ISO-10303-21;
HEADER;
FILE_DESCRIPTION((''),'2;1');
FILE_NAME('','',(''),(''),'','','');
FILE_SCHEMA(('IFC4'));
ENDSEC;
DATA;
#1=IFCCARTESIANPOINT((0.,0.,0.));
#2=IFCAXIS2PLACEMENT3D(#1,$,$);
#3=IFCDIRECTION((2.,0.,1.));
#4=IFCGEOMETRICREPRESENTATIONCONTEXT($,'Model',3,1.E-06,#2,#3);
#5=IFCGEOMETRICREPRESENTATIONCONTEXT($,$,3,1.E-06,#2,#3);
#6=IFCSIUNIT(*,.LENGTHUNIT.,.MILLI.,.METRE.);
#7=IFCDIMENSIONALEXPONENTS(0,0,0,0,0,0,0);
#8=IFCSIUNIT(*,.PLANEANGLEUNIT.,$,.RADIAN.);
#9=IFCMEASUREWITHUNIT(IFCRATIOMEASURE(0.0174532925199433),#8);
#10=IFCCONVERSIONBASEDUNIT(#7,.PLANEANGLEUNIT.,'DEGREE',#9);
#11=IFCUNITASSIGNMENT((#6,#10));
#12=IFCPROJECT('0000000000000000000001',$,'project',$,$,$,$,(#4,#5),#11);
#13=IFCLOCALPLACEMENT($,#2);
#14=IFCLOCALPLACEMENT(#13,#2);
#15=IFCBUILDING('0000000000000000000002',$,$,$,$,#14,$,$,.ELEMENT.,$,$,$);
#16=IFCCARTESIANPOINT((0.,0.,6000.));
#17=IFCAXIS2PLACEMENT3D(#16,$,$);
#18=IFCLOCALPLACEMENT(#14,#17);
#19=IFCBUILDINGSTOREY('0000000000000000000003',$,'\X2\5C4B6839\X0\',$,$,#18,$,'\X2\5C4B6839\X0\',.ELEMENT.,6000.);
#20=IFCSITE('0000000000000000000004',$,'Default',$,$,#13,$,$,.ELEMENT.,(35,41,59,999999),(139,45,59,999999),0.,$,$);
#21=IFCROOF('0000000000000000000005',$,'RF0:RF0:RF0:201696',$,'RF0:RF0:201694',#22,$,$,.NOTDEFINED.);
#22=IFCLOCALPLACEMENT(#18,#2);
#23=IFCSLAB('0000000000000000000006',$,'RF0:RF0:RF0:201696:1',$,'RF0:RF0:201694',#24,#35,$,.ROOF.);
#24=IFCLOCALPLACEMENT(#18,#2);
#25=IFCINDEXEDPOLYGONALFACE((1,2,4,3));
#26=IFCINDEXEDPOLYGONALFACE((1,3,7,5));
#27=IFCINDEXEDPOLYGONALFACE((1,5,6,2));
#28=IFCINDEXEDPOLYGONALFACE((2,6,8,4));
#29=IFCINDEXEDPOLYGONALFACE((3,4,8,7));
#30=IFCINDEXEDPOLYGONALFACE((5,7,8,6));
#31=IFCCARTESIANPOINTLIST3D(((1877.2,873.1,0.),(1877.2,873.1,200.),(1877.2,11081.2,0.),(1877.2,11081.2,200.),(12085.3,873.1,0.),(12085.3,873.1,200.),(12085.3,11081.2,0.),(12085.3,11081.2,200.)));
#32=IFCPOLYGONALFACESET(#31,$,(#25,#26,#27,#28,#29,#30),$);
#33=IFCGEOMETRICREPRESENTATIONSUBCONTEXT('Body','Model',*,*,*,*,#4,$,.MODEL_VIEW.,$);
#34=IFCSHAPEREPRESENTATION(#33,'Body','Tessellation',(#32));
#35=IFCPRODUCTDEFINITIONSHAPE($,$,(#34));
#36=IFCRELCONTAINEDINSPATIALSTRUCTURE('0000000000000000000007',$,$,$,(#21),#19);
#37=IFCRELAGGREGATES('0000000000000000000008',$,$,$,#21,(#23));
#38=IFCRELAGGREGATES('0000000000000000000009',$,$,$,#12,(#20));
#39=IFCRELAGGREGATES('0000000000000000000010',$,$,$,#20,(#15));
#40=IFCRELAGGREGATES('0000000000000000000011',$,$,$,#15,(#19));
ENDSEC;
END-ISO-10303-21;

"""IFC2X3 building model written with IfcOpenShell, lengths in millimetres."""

from ifc_helpers import new_model, entity, si_unit, converted_unit, direction, frame, frame_2d, origin, place, context, subcontext, project, spatial, rectangle, extrude, element, aggregate, save


model = new_model("IFC2X3")

# Units and contexts
model_context = context("Model", 3, precision=1e-06, world=origin(), true_north=direction((2.0, 0.0, 1.0)))
context_of_model = context(None, 3, precision=1e-06, world=origin(), true_north=direction((2.0, 0.0, 1.0)))
body_context = subcontext(model_context, "Body", "Model", "MODEL_VIEW")
ifc_project = project(units=[si_unit("LENGTHUNIT", "METRE", prefix="MILLI"), converted_unit("PLANEANGLEUNIT", "DEGREE", entity("IfcRatioMeasure", 0.0174532925199433), si_unit("PLANEANGLEUNIT", "RADIAN"), dimensions=[0, 0, 0, 0, 0, 0, 0])], contexts=[model_context, context_of_model])

# Site, building, storey
site_placement = place(None, origin())
site = spatial("IfcSite", under=ifc_project, at=site_placement, Name="Default", CompositionType="ELEMENT", RefLatitude=(35, 41, 59, 999999), RefLongitude=(139, 45, 59, 999999), RefElevation=0.0)
building_placement = place(site_placement, origin())
building = spatial("IfcBuilding", under=site, at=building_placement, CompositionType="ELEMENT")
storey_placement = place(building_placement, frame((0.0, 0.0, 6000.0)))
storey = spatial("IfcBuildingStorey", under=building, at=storey_placement, Name="屋根", LongName="屋根", CompositionType="ELEMENT", Elevation=6000.0)

# Roof, slab
roof_placement = place(storey_placement, origin())
roof = element("IfcRoof", 1, at=roof_placement, inside=storey, Name="RF0:RF0:RF0:201696", ObjectType="RF0:RF0:201694", ShapeType="NOTDEFINED")
slab_placement = place(storey_placement, origin())
slab = element("IfcSlab", 2, at=slab_placement, Name="RF0:RF0:RF0:201696:1", ObjectType="RF0:RF0:201694", PredefinedType="ROOF", context=body_context, shape_type="SweptSolid", body=[
    extrude(rectangle(XDim=10208.1, YDim=10208.1, at=frame_2d((0.0, 0.0), x_axis=(1.0, 0.0))), frame((6981.3, 5977.2, 0.0), z_axis=(0.0, 0.0, 1.0), x_axis=(-1.0, 0.0, 0.0)), (0.0, 0.0, 1.0), 200.0),
])
aggregate(roof, [slab])

save(model, "model.ifc")
